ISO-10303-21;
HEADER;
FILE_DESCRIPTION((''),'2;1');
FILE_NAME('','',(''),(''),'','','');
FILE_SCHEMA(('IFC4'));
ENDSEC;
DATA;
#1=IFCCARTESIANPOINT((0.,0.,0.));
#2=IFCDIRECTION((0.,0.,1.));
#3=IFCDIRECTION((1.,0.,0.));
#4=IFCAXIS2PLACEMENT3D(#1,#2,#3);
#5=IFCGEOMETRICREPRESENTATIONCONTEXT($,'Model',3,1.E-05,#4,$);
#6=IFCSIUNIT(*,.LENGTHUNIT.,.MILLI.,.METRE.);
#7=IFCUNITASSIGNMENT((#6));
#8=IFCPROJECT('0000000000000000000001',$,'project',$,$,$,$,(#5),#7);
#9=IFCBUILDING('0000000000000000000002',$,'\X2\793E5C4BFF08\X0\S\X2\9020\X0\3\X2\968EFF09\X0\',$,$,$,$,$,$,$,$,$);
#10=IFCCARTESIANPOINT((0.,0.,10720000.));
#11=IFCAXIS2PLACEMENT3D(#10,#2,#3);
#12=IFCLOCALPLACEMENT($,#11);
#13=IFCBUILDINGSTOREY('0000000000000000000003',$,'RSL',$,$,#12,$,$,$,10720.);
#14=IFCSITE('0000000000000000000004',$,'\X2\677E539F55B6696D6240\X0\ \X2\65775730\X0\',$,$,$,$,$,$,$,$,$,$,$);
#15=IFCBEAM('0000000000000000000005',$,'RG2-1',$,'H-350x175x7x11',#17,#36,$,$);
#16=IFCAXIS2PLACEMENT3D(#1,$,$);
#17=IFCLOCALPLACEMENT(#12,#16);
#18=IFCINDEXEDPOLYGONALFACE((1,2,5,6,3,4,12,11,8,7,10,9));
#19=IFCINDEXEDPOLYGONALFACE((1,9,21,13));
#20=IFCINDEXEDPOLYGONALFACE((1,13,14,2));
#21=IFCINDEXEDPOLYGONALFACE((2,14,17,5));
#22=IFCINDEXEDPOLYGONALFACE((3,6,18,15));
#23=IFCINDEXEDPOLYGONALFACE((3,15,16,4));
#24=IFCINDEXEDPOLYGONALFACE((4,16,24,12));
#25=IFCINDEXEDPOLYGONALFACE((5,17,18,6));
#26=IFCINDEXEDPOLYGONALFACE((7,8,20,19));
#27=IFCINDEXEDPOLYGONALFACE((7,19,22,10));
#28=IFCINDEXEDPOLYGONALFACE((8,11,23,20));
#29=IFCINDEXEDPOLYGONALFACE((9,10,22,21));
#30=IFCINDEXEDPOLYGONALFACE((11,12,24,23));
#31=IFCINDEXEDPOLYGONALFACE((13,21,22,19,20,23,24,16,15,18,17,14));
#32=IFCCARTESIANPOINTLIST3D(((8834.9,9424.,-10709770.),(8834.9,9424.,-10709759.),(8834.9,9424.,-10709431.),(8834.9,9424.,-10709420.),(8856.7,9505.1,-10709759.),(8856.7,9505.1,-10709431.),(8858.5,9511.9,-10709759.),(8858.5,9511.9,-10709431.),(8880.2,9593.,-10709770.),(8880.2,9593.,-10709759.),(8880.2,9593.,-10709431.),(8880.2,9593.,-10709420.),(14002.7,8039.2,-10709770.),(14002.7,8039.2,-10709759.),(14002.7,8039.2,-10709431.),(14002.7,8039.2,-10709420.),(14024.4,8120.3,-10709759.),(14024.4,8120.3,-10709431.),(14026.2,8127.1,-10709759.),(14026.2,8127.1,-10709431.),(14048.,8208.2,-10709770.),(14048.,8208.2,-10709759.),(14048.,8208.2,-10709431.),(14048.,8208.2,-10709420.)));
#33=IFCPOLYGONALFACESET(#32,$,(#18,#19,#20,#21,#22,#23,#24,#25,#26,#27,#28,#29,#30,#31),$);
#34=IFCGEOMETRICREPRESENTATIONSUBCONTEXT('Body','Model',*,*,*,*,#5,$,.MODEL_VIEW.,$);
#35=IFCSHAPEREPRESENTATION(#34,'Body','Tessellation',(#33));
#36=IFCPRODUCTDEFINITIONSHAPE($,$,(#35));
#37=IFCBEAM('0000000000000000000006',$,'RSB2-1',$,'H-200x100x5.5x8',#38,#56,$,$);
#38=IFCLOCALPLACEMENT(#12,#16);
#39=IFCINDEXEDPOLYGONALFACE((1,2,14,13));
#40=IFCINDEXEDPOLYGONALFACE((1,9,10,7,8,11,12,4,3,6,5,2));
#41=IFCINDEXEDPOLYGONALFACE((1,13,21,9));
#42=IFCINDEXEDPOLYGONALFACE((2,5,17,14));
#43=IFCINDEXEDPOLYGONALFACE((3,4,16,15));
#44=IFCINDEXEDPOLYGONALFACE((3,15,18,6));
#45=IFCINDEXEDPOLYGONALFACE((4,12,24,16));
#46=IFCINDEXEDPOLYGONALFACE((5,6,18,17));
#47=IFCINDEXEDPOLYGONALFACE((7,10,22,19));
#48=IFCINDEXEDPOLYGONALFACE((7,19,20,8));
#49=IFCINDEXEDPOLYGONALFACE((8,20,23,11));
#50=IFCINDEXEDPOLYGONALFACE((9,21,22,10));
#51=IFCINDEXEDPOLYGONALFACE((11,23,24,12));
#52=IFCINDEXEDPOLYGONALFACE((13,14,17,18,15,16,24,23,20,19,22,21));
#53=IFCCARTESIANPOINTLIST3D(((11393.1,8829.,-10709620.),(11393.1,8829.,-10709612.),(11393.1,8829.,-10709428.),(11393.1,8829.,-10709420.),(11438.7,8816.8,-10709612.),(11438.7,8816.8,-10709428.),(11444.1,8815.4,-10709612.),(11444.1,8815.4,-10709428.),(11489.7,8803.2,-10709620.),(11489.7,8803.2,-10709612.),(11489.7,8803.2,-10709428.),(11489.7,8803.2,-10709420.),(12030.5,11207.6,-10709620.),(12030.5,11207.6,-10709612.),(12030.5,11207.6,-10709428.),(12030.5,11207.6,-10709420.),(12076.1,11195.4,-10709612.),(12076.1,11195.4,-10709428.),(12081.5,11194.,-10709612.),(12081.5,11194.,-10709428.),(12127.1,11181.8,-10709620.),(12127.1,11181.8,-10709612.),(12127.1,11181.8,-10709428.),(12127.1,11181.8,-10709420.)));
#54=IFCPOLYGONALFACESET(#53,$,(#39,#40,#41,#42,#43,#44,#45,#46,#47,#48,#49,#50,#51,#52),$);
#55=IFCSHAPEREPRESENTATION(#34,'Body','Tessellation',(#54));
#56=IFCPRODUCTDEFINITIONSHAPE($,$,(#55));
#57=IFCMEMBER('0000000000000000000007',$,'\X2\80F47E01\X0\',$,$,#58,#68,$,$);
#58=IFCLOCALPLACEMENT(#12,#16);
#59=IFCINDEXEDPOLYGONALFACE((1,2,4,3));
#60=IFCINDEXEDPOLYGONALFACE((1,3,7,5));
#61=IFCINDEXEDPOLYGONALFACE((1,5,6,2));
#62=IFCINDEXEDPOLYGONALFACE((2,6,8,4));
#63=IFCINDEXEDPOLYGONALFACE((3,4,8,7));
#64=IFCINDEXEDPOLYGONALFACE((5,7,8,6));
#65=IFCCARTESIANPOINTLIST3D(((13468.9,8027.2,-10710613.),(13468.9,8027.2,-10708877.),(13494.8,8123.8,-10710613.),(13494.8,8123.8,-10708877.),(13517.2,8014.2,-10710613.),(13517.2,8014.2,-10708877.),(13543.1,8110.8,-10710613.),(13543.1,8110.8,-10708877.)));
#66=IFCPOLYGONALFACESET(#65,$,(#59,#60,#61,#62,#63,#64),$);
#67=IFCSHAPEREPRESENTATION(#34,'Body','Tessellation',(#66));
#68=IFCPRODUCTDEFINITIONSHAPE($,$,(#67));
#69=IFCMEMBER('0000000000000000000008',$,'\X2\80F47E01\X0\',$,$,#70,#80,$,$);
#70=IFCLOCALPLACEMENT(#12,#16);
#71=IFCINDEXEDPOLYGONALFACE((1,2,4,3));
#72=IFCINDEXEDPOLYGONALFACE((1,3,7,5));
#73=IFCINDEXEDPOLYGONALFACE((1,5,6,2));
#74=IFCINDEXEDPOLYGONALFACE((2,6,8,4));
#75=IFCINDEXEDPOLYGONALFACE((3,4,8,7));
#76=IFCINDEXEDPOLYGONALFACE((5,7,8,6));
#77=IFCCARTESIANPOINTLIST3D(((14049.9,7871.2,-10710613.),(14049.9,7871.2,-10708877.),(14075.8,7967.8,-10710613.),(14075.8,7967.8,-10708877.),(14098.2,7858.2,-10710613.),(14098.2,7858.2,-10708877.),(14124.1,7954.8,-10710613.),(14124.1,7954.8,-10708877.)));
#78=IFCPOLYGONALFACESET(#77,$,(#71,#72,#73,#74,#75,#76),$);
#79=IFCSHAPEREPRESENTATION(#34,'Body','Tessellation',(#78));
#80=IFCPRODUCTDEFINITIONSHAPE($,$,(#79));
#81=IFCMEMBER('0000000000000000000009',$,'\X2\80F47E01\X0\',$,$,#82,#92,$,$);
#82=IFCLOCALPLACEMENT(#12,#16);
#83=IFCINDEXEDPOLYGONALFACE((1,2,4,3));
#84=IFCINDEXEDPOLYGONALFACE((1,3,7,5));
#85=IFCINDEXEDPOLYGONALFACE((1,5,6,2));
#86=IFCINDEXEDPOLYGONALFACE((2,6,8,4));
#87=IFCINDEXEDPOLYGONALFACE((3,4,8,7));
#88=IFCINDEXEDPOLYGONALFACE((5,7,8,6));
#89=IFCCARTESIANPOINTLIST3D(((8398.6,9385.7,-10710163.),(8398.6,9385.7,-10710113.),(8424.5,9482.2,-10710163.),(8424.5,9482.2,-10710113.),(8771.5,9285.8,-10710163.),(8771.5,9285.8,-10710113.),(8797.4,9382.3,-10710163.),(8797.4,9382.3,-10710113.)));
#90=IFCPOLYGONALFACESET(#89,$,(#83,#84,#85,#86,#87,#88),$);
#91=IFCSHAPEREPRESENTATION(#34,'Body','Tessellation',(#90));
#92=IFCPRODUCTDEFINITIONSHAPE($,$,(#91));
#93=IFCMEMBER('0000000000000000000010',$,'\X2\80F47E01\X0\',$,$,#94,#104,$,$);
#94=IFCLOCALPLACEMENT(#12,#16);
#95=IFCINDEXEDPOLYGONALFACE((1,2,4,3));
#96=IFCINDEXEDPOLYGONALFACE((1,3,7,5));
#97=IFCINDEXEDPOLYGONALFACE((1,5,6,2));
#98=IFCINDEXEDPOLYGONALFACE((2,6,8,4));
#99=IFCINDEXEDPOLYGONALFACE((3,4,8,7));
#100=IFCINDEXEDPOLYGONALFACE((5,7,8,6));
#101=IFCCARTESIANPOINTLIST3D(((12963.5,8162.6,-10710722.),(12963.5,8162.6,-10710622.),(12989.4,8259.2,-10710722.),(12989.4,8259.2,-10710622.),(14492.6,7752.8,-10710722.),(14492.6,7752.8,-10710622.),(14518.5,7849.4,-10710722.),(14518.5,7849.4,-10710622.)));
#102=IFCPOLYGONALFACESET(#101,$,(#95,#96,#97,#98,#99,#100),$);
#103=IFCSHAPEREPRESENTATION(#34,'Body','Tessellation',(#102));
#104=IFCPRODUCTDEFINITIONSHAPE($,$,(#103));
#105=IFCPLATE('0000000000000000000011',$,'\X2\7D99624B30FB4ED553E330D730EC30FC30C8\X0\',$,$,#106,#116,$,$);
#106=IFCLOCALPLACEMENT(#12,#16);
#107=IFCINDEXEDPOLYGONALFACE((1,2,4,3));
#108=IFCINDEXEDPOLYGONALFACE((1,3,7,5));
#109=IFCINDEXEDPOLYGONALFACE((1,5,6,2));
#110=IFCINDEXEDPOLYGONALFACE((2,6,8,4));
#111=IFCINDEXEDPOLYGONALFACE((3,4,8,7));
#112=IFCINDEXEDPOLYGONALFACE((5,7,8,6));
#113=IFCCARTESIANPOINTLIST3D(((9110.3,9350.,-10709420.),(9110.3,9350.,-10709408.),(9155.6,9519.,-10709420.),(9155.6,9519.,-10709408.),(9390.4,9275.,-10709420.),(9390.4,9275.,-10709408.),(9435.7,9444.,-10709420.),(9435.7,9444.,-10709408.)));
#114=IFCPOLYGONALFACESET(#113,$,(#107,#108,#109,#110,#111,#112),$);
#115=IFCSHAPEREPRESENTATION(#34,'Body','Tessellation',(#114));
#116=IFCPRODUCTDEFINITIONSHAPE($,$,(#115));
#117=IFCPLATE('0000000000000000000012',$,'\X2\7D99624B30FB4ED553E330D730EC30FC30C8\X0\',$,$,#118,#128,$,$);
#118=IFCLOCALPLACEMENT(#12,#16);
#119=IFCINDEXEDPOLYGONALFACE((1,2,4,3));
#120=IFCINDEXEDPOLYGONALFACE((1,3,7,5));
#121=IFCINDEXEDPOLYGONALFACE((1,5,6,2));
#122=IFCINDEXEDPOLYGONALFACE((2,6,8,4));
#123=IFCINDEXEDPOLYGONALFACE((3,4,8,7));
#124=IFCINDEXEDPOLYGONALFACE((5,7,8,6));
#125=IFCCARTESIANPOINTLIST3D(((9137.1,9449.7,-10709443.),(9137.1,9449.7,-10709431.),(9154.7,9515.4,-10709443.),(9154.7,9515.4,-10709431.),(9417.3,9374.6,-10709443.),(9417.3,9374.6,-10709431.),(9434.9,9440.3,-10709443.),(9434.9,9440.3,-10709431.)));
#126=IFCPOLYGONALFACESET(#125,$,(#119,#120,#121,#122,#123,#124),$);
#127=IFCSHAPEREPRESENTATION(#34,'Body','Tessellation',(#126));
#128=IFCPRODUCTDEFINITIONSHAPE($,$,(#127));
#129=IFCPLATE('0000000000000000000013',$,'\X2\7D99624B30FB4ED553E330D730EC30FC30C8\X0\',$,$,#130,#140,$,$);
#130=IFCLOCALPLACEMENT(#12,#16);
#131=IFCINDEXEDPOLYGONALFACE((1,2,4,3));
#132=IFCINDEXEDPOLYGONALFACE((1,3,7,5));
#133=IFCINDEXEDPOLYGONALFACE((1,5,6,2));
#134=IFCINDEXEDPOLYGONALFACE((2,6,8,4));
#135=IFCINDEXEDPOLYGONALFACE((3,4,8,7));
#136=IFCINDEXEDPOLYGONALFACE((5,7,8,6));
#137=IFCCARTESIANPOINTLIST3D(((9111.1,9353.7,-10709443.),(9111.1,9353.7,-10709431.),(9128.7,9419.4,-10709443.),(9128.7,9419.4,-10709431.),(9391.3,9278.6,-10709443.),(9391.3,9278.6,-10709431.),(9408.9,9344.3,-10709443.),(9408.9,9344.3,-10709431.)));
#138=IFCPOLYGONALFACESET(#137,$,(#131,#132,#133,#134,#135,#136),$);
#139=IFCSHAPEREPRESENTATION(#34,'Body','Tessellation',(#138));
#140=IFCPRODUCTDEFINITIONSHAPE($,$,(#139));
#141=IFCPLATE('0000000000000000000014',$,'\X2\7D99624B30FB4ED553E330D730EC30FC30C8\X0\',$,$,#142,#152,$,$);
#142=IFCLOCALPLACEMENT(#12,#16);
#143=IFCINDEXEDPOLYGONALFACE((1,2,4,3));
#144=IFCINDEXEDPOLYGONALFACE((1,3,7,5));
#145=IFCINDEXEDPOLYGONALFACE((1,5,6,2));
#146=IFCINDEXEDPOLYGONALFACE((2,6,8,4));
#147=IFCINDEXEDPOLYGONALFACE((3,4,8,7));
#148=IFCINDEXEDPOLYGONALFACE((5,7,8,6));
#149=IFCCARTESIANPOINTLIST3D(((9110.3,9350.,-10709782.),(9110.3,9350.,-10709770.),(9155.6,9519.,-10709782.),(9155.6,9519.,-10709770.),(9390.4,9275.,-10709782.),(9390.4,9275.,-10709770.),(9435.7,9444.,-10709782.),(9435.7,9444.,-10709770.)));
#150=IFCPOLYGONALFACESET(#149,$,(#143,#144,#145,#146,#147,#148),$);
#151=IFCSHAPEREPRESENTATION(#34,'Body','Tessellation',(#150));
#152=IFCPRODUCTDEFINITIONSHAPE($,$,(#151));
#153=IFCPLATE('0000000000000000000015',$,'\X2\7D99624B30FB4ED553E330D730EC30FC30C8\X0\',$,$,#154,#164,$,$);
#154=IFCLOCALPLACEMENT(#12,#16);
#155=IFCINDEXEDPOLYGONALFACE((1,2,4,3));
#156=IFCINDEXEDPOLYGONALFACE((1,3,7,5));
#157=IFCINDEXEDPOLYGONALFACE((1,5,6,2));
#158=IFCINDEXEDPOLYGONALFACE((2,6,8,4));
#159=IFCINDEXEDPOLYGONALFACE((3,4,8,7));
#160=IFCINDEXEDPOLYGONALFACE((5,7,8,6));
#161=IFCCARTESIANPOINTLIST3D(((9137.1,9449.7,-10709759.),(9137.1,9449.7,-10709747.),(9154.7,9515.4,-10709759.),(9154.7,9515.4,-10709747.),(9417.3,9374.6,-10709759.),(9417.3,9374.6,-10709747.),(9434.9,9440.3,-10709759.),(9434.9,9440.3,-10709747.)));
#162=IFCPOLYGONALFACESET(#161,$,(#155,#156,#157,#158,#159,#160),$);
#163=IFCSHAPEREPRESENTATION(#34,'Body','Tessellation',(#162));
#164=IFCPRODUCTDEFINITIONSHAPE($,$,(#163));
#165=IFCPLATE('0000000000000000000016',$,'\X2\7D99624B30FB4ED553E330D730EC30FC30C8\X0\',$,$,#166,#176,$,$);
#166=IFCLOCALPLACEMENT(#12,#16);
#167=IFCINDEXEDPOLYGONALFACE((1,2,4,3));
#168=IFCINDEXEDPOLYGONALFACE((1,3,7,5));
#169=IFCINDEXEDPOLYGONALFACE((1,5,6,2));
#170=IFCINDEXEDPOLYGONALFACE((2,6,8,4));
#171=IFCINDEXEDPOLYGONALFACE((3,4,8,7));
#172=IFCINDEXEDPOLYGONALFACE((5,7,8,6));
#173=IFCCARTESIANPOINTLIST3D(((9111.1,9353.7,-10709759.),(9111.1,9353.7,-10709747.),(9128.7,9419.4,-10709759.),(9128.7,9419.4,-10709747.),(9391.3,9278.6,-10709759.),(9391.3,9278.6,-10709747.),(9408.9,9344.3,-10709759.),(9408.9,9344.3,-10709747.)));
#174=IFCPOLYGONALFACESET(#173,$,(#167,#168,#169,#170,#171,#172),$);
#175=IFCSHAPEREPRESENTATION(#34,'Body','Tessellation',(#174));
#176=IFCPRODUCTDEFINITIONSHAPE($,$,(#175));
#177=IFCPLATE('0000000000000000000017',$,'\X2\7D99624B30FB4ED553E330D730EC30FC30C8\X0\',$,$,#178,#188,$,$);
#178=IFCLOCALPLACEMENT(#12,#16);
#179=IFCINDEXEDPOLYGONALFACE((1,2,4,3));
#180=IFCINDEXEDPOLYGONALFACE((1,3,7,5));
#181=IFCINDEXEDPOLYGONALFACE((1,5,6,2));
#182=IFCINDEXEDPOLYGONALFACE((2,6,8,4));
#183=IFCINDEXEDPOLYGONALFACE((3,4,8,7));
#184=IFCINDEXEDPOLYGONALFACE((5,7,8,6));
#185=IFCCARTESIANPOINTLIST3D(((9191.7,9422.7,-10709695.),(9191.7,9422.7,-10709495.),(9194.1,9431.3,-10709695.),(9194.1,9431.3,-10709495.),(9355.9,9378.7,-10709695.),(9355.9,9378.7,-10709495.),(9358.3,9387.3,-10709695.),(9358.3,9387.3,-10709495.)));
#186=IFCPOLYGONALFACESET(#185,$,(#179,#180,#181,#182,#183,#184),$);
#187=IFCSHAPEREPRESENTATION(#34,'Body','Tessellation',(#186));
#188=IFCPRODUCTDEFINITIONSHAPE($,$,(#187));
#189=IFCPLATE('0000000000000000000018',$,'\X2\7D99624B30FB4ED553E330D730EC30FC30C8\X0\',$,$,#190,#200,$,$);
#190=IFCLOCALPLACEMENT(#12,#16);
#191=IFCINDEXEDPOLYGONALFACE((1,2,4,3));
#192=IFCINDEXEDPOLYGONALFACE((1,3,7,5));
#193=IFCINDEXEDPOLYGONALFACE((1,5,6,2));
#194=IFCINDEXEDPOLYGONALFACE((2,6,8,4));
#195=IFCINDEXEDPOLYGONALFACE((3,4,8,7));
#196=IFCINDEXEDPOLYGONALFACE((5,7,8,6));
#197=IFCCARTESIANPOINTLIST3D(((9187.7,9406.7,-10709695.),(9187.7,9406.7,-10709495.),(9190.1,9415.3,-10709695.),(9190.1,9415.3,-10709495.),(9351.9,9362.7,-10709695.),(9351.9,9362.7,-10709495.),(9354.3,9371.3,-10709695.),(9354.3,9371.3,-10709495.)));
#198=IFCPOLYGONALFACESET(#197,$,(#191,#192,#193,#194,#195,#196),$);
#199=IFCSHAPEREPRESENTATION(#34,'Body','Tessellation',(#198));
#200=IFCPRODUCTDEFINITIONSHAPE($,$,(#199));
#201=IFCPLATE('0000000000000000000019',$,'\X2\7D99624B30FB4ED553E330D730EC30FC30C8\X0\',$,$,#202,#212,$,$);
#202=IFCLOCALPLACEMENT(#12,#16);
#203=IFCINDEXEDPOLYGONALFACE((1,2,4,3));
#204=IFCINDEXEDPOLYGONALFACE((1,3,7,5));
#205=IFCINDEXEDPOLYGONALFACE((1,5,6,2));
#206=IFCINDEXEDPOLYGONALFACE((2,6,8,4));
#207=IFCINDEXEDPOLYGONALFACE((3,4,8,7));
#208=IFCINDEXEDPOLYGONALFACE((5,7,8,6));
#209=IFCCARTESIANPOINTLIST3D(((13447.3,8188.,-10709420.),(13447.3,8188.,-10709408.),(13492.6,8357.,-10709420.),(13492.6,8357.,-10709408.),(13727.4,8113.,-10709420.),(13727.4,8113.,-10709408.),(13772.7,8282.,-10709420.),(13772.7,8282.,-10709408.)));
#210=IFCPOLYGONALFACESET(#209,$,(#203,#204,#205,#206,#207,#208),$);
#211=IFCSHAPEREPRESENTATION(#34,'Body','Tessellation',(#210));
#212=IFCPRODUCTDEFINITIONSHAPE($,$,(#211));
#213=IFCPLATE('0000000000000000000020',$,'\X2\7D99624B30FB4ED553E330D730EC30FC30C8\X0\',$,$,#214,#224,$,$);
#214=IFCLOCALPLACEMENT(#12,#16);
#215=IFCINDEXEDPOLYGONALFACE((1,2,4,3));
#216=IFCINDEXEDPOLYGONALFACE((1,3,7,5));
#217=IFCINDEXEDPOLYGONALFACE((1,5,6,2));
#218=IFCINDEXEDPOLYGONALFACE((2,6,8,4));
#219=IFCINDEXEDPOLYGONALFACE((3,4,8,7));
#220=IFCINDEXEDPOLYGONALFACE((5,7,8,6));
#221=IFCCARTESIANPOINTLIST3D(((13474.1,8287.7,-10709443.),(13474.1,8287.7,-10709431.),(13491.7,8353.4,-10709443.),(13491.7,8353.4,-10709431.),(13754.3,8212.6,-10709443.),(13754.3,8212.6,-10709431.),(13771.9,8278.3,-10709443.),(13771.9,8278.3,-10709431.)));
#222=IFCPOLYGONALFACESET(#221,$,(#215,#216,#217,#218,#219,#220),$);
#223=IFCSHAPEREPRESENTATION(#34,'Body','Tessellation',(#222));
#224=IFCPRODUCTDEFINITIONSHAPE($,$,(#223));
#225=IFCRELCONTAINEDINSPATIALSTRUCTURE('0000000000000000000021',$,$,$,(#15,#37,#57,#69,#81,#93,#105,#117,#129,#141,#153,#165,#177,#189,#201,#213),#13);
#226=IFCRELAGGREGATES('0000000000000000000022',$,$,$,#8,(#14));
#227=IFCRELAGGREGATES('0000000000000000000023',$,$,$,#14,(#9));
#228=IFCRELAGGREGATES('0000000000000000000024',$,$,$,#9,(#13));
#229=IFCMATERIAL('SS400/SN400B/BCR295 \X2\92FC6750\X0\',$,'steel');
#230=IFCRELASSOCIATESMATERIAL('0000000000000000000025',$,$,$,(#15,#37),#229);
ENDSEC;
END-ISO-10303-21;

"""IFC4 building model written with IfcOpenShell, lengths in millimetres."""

from ifc_helpers import new_model, si_unit, frame, origin, origin_with_axes, place, context, subcontext, project, spatial, rectangle, i_section, extrude, material, element, save


model = new_model("IFC4")

# Units and contexts
model_context = context("Model", 3, precision=1e-05, world=origin_with_axes())
body_context = subcontext(model_context, "Body", "Model", "MODEL_VIEW")
ifc_project = project(units=[si_unit("LENGTHUNIT", "METRE", prefix="MILLI")], contexts=[model_context])

# Site, building, storey
site = spatial("IfcSite", under=ifc_project, Name="松原営業所 敷地")
building = spatial("IfcBuilding", under=site, Name="社屋（S造3階）")
storey_placement = place(None, frame((0.0, 0.0, 10720000.0), z_axis=(0.0, 0.0, 1.0), x_axis=(1.0, 0.0, 0.0)))
storey = spatial("IfcBuildingStorey", under=building, at=storey_placement, Name="RSL", Elevation=10720.0)

# Beams
ifc_material = material(Name="SS400/SN400B/BCR295 鋼材", Category="steel")
beam_1_placement = place(storey_placement, frame((8857.6, 9508.5, -10709420.0), z_axis=(0.965923, -0.25883, 0.0), x_axis=(0.25883, 0.965923, 0.0)))
element("IfcBeam", 1, at=beam_1_placement, inside=storey, material=ifc_material, Name="RG2-1", ObjectType="H-350x175x7x11", context=body_context, shape_type="SweptSolid", body=[
    extrude(i_section(OverallWidth=175.0, OverallDepth=350.0, WebThickness=7.0, FlangeThickness=11.0), frame((0.0, -175.0, 0.0)), (0.0, 0.0, 1.0), 5350.0),
])
beam_2_placement = place(storey_placement, frame((11441.4, 8816.1, -10709420.0), z_axis=(0.25884, 0.96592, 0.0), x_axis=(-0.96592, 0.25884, 0.0)))
element("IfcBeam", 2, at=beam_2_placement, inside=storey, material=ifc_material, Name="RSB2-1", ObjectType="H-200x100x5.5x8", context=body_context, shape_type="SweptSolid", body=[
    extrude(i_section(OverallWidth=100.0, OverallDepth=200.0, WebThickness=5.5, FlangeThickness=8.0), frame((0.0, -100.0, 0.0)), (0.0, 0.0, 1.0), 2462.5),
])

# Members
for number, where, z_axis, x_axis, name in (
    (3, (13481.9, 8075.5, -10709745.0), (0.965926, -0.258819, 0.0), (0.258819, 0.965926, 0.0), "胴縁"),
    (4, (14062.9, 7919.5, -10709745.0), (0.965926, -0.258819, 0.0), (0.258819, 0.965926, 0.0), "胴縁"),
):
    element("IfcMember", number, at=place(storey_placement, frame(where, z_axis=z_axis, x_axis=x_axis)), inside=storey, Name=name, context=body_context, shape_type="SweptSolid", body=[
        extrude(rectangle(XDim=100.0, YDim=1736.0), origin(), (0.0, 0.0, 1.0), 50.0),
    ])
member_1_placement = place(storey_placement, frame((8411.6, 9434.0, -10710138.0), z_axis=(0.965926, -0.258819, 0.0), x_axis=(0.258819, 0.965926, 0.0)))
element("IfcMember", 5, at=member_1_placement, inside=storey, Name="胴縁", context=body_context, shape_type="SweptSolid", body=[
    extrude(rectangle(XDim=100.0, YDim=50.0), origin(), (0.0, 0.0, 1.0), 386.0),
])
member_2_placement = place(storey_placement, frame((12976.5, 8210.9, -10710672.0), z_axis=(0.965926, -0.258819, 0.0), x_axis=(0.258819, 0.965926, 0.0)))
element("IfcMember", 6, at=member_2_placement, inside=storey, Name="胴縁", context=body_context, shape_type="SweptSolid", body=[
    extrude(rectangle(XDim=100.0, YDim=100.0), origin(), (0.0, 0.0, 1.0), 1583.0),
])

# Plates
plate_1_placement = place(storey_placement, frame((9132.9, 9434.5, -10709414.0), z_axis=(0.965926, -0.258819, 0.0), x_axis=(0.258819, 0.965926, 0.0)))
element("IfcPlate", 7, at=plate_1_placement, inside=storey, Name="継手・仕口プレート", context=body_context, shape_type="SweptSolid", body=[
    extrude(rectangle(XDim=175.0, YDim=12.0), origin(), (0.0, 0.0, 1.0), 290.0),
])
for number, where, z_axis, x_axis, name in (
    (8, (9145.9, 9482.5, -10709437.0), (0.965926, -0.258819, 0.0), (0.258819, 0.965926, 0.0), "継手・仕口プレート"),
    (9, (9119.9, 9386.5, -10709437.0), (0.965926, -0.258819, 0.0), (0.258819, 0.965926, 0.0), "継手・仕口プレート"),
):
    element("IfcPlate", number, at=place(storey_placement, frame(where, z_axis=z_axis, x_axis=x_axis)), inside=storey, Name=name, context=body_context, shape_type="SweptSolid", body=[
        extrude(rectangle(XDim=68.0, YDim=12.0), origin(), (0.0, 0.0, 1.0), 290.0),
    ])
plate_2_placement = place(storey_placement, frame((9132.9, 9434.5, -10709776.0), z_axis=(0.965926, -0.258819, 0.0), x_axis=(0.258819, 0.965926, 0.0)))
element("IfcPlate", 10, at=plate_2_placement, inside=storey, Name="継手・仕口プレート", context=body_context, shape_type="SweptSolid", body=[
    extrude(rectangle(XDim=175.0, YDim=12.0), origin(), (0.0, 0.0, 1.0), 290.0),
])
for number, where, z_axis, x_axis, name in (
    (11, (9145.9, 9482.5, -10709753.0), (0.965926, -0.258819, 0.0), (0.258819, 0.965926, 0.0), "継手・仕口プレート"),
    (12, (9119.9, 9386.5, -10709753.0), (0.965926, -0.258819, 0.0), (0.258819, 0.965926, 0.0), "継手・仕口プレート"),
):
    element("IfcPlate", number, at=place(storey_placement, frame(where, z_axis=z_axis, x_axis=x_axis)), inside=storey, Name=name, context=body_context, shape_type="SweptSolid", body=[
        extrude(rectangle(XDim=68.0, YDim=12.0), origin(), (0.0, 0.0, 1.0), 290.0),
    ])
for number, where, z_axis, x_axis, name in (
    (13, (9192.9, 9427.0, -10709595.0), (0.965926, -0.258819, 0.0), (0.258819, 0.965926, 0.0), "継手・仕口プレート"),
    (14, (9188.9, 9411.0, -10709595.0), (0.965926, -0.258819, 0.0), (0.258819, 0.965926, 0.0), "継手・仕口プレート"),
):
    element("IfcPlate", number, at=place(storey_placement, frame(where, z_axis=z_axis, x_axis=x_axis)), inside=storey, Name=name, context=body_context, shape_type="SweptSolid", body=[
        extrude(rectangle(XDim=9.0, YDim=200.0), origin(), (0.0, 0.0, 1.0), 170.0),
    ])
plate_3_placement = place(storey_placement, frame((13469.9, 8272.5, -10709414.0), z_axis=(0.965926, -0.258819, 0.0), x_axis=(0.258819, 0.965926, 0.0)))
element("IfcPlate", 15, at=plate_3_placement, inside=storey, Name="継手・仕口プレート", context=body_context, shape_type="SweptSolid", body=[
    extrude(rectangle(XDim=175.0, YDim=12.0), origin(), (0.0, 0.0, 1.0), 290.0),
])
for number, where, z_axis, x_axis, name in (
    (16, (13482.9, 8320.5, -10709437.0), (0.965926, -0.258819, 0.0), (0.258819, 0.965926, 0.0), "継手・仕口プレート"),
):
    element("IfcPlate", number, at=place(storey_placement, frame(where, z_axis=z_axis, x_axis=x_axis)), inside=storey, Name=name, context=body_context, shape_type="SweptSolid", body=[
        extrude(rectangle(XDim=68.0, YDim=12.0), origin(), (0.0, 0.0, 1.0), 290.0),
    ])

save(model, "model.ifc")
